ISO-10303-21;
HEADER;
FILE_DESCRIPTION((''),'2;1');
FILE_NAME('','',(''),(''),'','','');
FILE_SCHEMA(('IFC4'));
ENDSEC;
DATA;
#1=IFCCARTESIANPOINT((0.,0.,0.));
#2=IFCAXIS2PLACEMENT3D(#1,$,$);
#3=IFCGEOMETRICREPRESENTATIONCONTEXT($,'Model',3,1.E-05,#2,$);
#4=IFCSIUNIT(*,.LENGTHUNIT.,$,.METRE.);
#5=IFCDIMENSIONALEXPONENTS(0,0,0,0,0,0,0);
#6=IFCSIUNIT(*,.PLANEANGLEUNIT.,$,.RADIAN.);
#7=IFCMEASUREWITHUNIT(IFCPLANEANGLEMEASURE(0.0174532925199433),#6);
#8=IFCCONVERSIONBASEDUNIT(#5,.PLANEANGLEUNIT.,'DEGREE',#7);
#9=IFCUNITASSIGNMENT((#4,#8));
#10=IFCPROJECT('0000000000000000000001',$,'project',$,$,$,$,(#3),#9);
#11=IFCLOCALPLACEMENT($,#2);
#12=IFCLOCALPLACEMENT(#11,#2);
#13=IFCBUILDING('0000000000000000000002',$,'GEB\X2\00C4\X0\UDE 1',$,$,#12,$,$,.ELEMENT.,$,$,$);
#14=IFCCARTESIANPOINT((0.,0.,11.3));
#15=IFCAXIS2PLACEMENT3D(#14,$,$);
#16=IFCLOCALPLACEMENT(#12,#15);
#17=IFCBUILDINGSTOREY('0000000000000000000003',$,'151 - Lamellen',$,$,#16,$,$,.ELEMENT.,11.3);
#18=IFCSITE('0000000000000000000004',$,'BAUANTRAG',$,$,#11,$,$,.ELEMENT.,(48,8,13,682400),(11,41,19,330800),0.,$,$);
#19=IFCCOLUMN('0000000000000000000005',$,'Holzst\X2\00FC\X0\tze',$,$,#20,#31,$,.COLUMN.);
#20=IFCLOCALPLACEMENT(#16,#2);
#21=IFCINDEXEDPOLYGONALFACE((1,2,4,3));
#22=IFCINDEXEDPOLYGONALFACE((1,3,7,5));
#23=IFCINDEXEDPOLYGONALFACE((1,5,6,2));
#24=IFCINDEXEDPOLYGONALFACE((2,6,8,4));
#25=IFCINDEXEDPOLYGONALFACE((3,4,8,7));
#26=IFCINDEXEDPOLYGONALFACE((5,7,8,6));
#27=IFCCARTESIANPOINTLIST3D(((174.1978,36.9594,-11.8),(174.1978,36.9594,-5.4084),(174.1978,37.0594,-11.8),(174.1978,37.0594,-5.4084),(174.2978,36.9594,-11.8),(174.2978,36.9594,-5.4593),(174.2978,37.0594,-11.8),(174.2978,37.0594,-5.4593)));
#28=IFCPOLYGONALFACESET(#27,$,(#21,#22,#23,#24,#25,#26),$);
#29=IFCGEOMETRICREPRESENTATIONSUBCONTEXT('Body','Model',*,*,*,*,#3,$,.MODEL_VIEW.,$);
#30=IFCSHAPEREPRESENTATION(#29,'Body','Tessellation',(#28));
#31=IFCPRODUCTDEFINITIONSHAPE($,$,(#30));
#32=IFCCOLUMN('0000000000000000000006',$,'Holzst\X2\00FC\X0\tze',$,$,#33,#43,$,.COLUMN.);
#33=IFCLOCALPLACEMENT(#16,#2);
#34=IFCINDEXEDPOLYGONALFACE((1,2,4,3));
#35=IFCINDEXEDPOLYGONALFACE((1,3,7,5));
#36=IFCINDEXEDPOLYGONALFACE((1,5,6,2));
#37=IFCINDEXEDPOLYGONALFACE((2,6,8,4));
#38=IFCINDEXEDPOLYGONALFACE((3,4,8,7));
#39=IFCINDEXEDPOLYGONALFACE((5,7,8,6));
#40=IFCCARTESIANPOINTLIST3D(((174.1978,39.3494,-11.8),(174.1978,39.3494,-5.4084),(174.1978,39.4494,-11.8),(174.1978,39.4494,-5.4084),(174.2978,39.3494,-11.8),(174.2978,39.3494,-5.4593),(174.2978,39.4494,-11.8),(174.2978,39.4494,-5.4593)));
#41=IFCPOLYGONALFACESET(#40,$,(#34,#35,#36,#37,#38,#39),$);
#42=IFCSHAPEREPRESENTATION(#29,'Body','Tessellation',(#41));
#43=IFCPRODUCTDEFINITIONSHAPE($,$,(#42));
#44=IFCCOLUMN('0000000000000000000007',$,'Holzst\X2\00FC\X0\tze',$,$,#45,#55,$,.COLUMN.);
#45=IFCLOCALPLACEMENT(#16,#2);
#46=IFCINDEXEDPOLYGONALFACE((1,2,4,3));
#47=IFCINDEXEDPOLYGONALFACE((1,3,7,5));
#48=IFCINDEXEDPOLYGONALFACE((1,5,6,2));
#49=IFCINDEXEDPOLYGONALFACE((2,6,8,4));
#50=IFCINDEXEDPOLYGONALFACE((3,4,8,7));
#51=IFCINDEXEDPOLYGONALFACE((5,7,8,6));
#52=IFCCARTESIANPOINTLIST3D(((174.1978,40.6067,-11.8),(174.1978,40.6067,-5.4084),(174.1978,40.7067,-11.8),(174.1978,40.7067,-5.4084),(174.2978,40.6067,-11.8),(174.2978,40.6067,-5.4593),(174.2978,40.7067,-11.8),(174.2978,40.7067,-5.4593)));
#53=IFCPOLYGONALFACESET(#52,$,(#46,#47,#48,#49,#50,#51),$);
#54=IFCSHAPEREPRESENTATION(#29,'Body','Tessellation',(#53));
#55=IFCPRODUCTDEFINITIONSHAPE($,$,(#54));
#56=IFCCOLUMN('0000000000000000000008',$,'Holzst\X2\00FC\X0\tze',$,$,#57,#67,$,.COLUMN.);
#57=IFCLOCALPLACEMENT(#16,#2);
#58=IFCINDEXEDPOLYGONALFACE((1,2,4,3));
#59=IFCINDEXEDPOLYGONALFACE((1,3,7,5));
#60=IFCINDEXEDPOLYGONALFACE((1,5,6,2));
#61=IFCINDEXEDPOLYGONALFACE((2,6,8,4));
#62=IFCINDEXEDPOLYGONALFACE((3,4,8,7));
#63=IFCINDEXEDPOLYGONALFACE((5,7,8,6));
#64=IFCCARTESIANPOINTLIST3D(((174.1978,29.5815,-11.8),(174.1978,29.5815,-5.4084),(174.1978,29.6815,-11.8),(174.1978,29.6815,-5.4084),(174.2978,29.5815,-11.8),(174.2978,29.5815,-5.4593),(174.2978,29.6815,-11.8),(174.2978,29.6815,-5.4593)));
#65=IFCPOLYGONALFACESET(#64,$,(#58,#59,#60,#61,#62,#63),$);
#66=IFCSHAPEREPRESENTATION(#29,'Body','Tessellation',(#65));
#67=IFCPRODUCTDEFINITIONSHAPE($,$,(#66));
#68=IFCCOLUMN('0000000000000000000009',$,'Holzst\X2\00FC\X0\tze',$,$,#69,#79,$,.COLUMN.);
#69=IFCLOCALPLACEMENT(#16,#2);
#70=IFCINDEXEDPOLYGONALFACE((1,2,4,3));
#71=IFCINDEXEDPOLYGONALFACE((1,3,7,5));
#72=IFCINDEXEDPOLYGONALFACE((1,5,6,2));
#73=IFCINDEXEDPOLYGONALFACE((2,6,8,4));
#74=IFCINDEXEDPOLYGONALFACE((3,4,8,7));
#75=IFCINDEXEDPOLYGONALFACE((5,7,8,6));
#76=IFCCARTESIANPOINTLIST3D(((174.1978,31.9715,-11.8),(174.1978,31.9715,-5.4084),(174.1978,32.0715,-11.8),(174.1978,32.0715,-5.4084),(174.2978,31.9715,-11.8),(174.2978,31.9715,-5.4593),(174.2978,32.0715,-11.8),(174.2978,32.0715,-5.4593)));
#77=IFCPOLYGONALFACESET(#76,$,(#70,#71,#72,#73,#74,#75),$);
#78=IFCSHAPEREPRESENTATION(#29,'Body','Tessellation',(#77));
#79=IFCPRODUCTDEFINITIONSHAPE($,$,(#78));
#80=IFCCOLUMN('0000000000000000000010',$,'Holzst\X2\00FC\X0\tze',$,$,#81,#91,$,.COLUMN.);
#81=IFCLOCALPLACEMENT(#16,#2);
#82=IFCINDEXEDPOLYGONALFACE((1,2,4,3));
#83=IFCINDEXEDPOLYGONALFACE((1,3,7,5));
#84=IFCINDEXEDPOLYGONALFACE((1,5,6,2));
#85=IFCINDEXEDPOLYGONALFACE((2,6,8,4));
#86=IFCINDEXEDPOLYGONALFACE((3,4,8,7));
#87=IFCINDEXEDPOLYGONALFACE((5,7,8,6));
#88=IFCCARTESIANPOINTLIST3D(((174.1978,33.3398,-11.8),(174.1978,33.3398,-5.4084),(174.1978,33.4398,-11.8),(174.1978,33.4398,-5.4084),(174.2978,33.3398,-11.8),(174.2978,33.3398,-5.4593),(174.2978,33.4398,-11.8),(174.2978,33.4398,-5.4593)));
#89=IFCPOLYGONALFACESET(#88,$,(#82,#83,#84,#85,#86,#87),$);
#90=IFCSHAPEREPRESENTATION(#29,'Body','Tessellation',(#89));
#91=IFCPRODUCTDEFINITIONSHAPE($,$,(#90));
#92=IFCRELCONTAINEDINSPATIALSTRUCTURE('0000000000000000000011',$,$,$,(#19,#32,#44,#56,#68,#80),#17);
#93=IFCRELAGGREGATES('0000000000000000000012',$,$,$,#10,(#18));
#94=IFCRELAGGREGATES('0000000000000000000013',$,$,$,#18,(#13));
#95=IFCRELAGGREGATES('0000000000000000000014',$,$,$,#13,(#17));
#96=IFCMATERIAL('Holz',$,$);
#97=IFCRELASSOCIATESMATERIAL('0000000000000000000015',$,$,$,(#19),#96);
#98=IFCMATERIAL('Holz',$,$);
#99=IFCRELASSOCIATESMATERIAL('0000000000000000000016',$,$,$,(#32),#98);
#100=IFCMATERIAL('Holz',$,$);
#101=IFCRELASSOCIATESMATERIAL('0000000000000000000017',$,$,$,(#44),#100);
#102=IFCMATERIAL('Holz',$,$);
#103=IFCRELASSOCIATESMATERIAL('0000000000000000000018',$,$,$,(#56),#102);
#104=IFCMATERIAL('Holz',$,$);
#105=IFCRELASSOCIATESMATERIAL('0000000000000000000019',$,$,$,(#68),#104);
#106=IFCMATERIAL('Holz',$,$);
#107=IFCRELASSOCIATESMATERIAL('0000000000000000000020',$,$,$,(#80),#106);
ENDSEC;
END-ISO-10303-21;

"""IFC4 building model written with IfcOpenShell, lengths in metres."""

from ifc_helpers import new_model, entity, si_unit, converted_unit, frame, frame_2d, origin, origin_with_axes, place, context, subcontext, project, spatial, rectangle, extrude, clip, halfspace, material, element, save


model = new_model("IFC4")

# Units and contexts
model_context = context("Model", 3, precision=1e-05, world=origin())
body_context = subcontext(model_context, "Body", "Model", "MODEL_VIEW")
ifc_project = project(units=[si_unit("LENGTHUNIT", "METRE"), converted_unit("PLANEANGLEUNIT", "DEGREE", entity("IfcPlaneAngleMeasure", 0.0174532925199433), si_unit("PLANEANGLEUNIT", "RADIAN"), dimensions=[0, 0, 0, 0, 0, 0, 0])], contexts=[model_context])

# Site, building, storey
site_placement = place(None, origin())
site = spatial("IfcSite", under=ifc_project, at=site_placement, Name="BAUANTRAG", CompositionType="ELEMENT", RefLatitude=(48, 8, 13, 682400), RefLongitude=(11, 41, 19, 330800), RefElevation=0.0)
building_placement = place(site_placement, origin())
building = spatial("IfcBuilding", under=site, at=building_placement, Name="GEBÄUDE 1", CompositionType="ELEMENT")
storey_placement = place(building_placement, frame((0.0, 0.0, 11.3)))
storey = spatial("IfcBuildingStorey", under=building, at=storey_placement, Name="151 - Lamellen", CompositionType="ELEMENT", Elevation=11.3)

# Columns
ifc_material_1 = material(Name="Holz")
column_1_placement = place(storey_placement, frame((174.2978, 36.9594, -11.8)))
element("IfcColumn", 1, at=column_1_placement, inside=storey, material=ifc_material_1, Name="Holzstütze", PredefinedType="COLUMN", context=body_context, shape_type="Clipping", body=[
    clip(extrude(rectangle(XDim=0.1, YDim=0.1, at=frame_2d((-0.05, 0.05), x_axis=(0.0, 1.0))), origin_with_axes(), (0.0, 0.0, 1.0), 6.3916), halfspace(frame((-0.05, 0.05, 6.3661), z_axis=(-0.45399, 0.0, -0.891007), x_axis=(0.891007, 0.0, -0.45399)), True)),
])
ifc_material_2 = material(Name="Holz")
column_2_placement = place(storey_placement, frame((174.2978, 39.3494, -11.8)))
element("IfcColumn", 2, at=column_2_placement, inside=storey, material=ifc_material_2, Name="Holzstütze", PredefinedType="COLUMN", context=body_context, shape_type="Clipping", body=[
    clip(extrude(rectangle(XDim=0.1, YDim=0.1, at=frame_2d((-0.05, 0.05), x_axis=(0.0, 1.0))), origin_with_axes(), (0.0, 0.0, 1.0), 6.3916), halfspace(frame((-0.05, 0.05, 6.3661), z_axis=(-0.45399, 0.0, -0.891007), x_axis=(0.891007, 0.0, -0.45399)), True)),
])
ifc_material_3 = material(Name="Holz")
column_3_placement = place(storey_placement, frame((174.2978, 40.6067, -11.8)))
element("IfcColumn", 3, at=column_3_placement, inside=storey, material=ifc_material_3, Name="Holzstütze", PredefinedType="COLUMN", context=body_context, shape_type="Clipping", body=[
    clip(extrude(rectangle(XDim=0.1, YDim=0.1, at=frame_2d((-0.05, 0.05), x_axis=(0.0, 1.0))), origin_with_axes(), (0.0, 0.0, 1.0), 6.3916), halfspace(frame((-0.05, 0.05, 6.3661), z_axis=(-0.45399, 0.0, -0.891007), x_axis=(0.891007, 0.0, -0.45399)), True)),
])
ifc_material_4 = material(Name="Holz")
column_4_placement = place(storey_placement, frame((174.2978, 29.5815, -11.8)))
element("IfcColumn", 4, at=column_4_placement, inside=storey, material=ifc_material_4, Name="Holzstütze", PredefinedType="COLUMN", context=body_context, shape_type="Clipping", body=[
    clip(extrude(rectangle(XDim=0.1, YDim=0.1, at=frame_2d((-0.05, 0.05), x_axis=(0.0, 1.0))), origin_with_axes(), (0.0, 0.0, 1.0), 6.3916), halfspace(frame((-0.05, 0.05, 6.3661), z_axis=(-0.45399, 0.0, -0.891007), x_axis=(0.891007, 0.0, -0.45399)), True)),
])
ifc_material_5 = material(Name="Holz")
column_5_placement = place(storey_placement, frame((174.2978, 31.9715, -11.8)))
element("IfcColumn", 5, at=column_5_placement, inside=storey, material=ifc_material_5, Name="Holzstütze", PredefinedType="COLUMN", context=body_context, shape_type="Clipping", body=[
    clip(extrude(rectangle(XDim=0.1, YDim=0.1, at=frame_2d((-0.05, 0.05), x_axis=(0.0, 1.0))), origin_with_axes(), (0.0, 0.0, 1.0), 6.3916), halfspace(frame((-0.05, 0.05, 6.3661), z_axis=(-0.45399, 0.0, -0.891007), x_axis=(0.891007, 0.0, -0.45399)), True)),
])
ifc_material_6 = material(Name="Holz")
column_6_placement = place(storey_placement, frame((174.2978, 33.3398, -11.8)))
element("IfcColumn", 6, at=column_6_placement, inside=storey, material=ifc_material_6, Name="Holzstütze", PredefinedType="COLUMN", context=body_context, shape_type="Clipping", body=[
    clip(extrude(rectangle(XDim=0.1, YDim=0.1, at=frame_2d((-0.05, 0.05), x_axis=(0.0, 1.0))), origin_with_axes(), (0.0, 0.0, 1.0), 6.3916), halfspace(frame((-0.05, 0.05, 6.3661), z_axis=(-0.45399, 0.0, -0.891007), x_axis=(0.891007, 0.0, -0.45399)), True)),
])

save(model, "model.ifc")
